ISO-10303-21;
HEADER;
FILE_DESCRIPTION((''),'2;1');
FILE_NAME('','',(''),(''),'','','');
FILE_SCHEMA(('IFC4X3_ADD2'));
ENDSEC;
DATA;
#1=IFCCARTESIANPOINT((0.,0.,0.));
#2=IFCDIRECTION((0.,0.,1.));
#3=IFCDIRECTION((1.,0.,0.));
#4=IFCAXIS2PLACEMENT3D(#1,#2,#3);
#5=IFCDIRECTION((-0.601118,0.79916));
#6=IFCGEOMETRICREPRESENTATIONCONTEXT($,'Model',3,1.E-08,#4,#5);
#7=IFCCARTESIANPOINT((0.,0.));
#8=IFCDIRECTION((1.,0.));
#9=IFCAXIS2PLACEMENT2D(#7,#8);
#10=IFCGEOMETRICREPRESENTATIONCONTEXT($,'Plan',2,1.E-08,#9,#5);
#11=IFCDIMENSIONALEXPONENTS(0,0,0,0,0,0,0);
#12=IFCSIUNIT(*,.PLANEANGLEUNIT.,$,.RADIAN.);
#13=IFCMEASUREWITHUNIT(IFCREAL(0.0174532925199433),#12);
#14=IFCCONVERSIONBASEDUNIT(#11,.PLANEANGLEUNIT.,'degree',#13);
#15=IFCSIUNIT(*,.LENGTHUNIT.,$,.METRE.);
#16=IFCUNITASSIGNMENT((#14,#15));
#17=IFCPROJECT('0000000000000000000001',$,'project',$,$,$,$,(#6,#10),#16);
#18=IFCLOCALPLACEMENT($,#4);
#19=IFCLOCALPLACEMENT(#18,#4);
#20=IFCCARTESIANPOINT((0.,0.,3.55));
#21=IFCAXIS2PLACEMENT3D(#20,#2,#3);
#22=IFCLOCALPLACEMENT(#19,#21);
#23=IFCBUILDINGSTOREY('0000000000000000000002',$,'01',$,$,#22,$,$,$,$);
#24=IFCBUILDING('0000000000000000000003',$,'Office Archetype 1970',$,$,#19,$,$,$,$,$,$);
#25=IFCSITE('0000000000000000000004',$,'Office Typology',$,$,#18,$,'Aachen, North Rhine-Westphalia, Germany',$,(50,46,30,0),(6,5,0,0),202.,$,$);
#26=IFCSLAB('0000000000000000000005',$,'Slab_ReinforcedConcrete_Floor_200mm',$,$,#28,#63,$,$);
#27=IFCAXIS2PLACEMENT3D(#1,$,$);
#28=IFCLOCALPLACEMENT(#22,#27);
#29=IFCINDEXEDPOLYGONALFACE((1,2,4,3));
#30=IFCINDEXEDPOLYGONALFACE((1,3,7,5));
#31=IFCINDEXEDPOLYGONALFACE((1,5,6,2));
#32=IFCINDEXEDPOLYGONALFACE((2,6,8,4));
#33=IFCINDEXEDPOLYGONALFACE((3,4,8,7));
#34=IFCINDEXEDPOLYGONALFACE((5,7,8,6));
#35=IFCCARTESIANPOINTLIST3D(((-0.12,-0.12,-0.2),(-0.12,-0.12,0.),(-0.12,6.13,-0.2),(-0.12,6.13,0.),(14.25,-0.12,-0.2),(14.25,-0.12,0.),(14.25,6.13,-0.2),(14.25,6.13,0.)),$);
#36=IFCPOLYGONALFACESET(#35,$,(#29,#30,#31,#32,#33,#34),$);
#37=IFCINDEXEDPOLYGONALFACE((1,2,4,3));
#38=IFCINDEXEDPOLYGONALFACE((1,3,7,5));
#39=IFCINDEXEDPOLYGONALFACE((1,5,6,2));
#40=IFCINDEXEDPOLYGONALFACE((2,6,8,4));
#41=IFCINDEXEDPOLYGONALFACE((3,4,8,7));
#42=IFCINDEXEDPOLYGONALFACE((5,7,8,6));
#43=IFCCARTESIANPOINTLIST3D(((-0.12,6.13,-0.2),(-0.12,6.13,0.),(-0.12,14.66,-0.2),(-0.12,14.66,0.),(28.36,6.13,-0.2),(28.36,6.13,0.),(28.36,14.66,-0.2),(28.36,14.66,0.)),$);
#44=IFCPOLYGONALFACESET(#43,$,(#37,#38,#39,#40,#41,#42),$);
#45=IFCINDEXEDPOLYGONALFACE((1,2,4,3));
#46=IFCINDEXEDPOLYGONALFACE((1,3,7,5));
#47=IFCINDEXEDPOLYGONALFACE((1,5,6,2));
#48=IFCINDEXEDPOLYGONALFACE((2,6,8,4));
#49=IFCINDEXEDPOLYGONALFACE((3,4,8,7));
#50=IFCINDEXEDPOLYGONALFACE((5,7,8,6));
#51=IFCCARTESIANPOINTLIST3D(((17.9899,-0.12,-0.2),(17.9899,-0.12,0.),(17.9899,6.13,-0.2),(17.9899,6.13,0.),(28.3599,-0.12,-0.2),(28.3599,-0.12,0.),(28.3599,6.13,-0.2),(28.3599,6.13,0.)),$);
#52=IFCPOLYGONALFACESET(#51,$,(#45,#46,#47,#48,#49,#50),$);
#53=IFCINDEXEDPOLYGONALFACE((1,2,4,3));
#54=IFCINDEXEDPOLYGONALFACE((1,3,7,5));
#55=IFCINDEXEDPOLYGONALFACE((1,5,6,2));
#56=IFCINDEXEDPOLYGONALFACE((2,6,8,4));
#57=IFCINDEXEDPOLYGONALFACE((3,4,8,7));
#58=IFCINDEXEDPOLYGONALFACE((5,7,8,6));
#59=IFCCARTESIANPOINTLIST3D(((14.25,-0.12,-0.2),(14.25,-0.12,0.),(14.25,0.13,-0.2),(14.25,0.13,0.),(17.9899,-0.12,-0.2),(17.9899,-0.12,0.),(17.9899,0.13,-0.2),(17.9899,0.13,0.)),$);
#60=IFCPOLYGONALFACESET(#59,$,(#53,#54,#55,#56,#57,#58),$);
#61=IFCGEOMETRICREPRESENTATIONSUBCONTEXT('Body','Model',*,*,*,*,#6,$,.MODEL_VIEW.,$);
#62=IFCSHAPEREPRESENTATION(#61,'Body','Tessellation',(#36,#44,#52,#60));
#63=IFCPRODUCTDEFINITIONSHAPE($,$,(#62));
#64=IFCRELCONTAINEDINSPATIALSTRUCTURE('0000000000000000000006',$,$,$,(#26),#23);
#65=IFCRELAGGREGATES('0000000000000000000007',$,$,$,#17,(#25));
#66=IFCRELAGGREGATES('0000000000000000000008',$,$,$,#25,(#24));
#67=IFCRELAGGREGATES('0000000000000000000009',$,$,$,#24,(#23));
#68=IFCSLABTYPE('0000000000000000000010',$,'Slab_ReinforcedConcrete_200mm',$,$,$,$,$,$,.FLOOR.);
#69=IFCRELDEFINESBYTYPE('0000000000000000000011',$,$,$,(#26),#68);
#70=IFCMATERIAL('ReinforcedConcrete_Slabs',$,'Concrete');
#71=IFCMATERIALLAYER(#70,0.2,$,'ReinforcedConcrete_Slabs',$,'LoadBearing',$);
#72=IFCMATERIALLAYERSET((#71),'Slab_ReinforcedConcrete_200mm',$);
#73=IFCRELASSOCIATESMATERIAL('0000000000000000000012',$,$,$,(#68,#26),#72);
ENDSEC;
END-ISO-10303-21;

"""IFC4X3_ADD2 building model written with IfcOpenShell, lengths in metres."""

from ifc_helpers import new_model, entity, si_unit, converted_unit, direction, frame, origin_with_axes, origin_2d_with_axis, place, context, subcontext, project, spatial, indexed_curve, outline, extrude, material, layer, layer_set, layer_usage, type_object, element, save


model = new_model("IFC4X3_ADD2")

# Units and contexts
model_context = context("Model", 3, precision=1e-08, world=origin_with_axes(), true_north=direction((-0.601118, 0.79916)))
plan_context = context("Plan", 2, precision=1e-08, world=origin_2d_with_axis(), true_north=direction((-0.601118, 0.79916)))
body_context = subcontext(model_context, "Body", "Model", "MODEL_VIEW")
ifc_project = project(units=[converted_unit("PLANEANGLEUNIT", "degree", entity("IfcReal", 0.0174532925199433), si_unit("PLANEANGLEUNIT", "RADIAN"), dimensions=[0, 0, 0, 0, 0, 0, 0]), si_unit("LENGTHUNIT", "METRE")], contexts=[model_context, plan_context])

# Site, building, storey
site_placement = place(None, origin_with_axes())
site = spatial("IfcSite", under=ifc_project, at=site_placement, Name="Office Typology", LongName="Aachen, North Rhine-Westphalia, Germany", RefLatitude=(50, 46, 30, 0), RefLongitude=(6, 5, 0, 0), RefElevation=202.0)
building_placement = place(site_placement, origin_with_axes())
building = spatial("IfcBuilding", under=site, at=building_placement, Name="Office Archetype 1970")
storey_placement = place(building_placement, frame((0.0, 0.0, 3.55), z_axis=(0.0, 0.0, 1.0), x_axis=(1.0, 0.0, 0.0)))
storey = spatial("IfcBuildingStorey", under=building, at=storey_placement, Name="01")

# Slab
ifc_material_1 = material(Name="ReinforcedConcrete_Slabs", Category="Concrete")
ifc_layer_1 = layer(ifc_material_1, 0.2, Name="ReinforcedConcrete_Slabs", Category="LoadBearing")
ifc_layer_set_1 = layer_set([ifc_layer_1], Name="Slab_ReinforcedConcrete_200mm")
slab_type_1 = type_object("IfcSlabType", Name="Slab_ReinforcedConcrete_200mm", PredefinedType="FLOOR", material=ifc_layer_set_1)
ifc_layer_usage_1 = layer_usage(ifc_layer_set_1, "AXIS3", "POSITIVE", 0.0)
slab_1_placement = place(storey_placement, frame((17.9899, 6.13, 0.0), z_axis=(0.0, 0.0, 1.0), x_axis=(1.0, 0.0, 0.0)))
element("IfcSlab", 1, at=slab_1_placement, inside=storey, type_object=slab_type_1, material=ifc_layer_usage_1, Name="Slab_ReinforcedConcrete_Floor_200mm", context=body_context, shape_type="SweptSolid", body=[
    extrude(outline(indexed_curve([(0.0, -6.25), (14.37, -6.25), (14.37, 0.0), (0.0, 0.0), (0.0, -6.25)])), frame((-18.1099, 0.0, -0.2), z_axis=(0.0, 0.0, 1.0), x_axis=(1.0, 0.0, 0.0)), (0.0, 0.0, 1.0), 0.2),
    extrude(outline(indexed_curve([(0.0, 0.0), (28.48, 0.0), (28.48, -8.53), (0.0, -8.53), (0.0, 0.0)])), frame((-18.1099, 8.53, -0.2), z_axis=(0.0, 0.0, 1.0), x_axis=(1.0, 0.0, 0.0)), (0.0, 0.0, 1.0), 0.2),
    extrude(outline(indexed_curve([(0.0, 0.0), (0.0, -6.25), (10.37, -6.25), (10.37, 0.0), (0.0, 0.0)])), frame((0.0, 0.0, -0.2), z_axis=(0.0, 0.0, 1.0), x_axis=(1.0, 0.0, 0.0)), (0.0, 0.0, 1.0), 0.2),
    extrude(outline(indexed_curve([(0.0, 0.0), (3.7399, 0.0), (3.7399, 0.25), (0.0, 0.25), (0.0, 0.0)])), frame((-3.7399, -6.25, -0.2), z_axis=(0.0, 0.0, 1.0), x_axis=(1.0, 0.0, 0.0)), (0.0, 0.0, 1.0), 0.2),
])

save(model, "model.ifc")
